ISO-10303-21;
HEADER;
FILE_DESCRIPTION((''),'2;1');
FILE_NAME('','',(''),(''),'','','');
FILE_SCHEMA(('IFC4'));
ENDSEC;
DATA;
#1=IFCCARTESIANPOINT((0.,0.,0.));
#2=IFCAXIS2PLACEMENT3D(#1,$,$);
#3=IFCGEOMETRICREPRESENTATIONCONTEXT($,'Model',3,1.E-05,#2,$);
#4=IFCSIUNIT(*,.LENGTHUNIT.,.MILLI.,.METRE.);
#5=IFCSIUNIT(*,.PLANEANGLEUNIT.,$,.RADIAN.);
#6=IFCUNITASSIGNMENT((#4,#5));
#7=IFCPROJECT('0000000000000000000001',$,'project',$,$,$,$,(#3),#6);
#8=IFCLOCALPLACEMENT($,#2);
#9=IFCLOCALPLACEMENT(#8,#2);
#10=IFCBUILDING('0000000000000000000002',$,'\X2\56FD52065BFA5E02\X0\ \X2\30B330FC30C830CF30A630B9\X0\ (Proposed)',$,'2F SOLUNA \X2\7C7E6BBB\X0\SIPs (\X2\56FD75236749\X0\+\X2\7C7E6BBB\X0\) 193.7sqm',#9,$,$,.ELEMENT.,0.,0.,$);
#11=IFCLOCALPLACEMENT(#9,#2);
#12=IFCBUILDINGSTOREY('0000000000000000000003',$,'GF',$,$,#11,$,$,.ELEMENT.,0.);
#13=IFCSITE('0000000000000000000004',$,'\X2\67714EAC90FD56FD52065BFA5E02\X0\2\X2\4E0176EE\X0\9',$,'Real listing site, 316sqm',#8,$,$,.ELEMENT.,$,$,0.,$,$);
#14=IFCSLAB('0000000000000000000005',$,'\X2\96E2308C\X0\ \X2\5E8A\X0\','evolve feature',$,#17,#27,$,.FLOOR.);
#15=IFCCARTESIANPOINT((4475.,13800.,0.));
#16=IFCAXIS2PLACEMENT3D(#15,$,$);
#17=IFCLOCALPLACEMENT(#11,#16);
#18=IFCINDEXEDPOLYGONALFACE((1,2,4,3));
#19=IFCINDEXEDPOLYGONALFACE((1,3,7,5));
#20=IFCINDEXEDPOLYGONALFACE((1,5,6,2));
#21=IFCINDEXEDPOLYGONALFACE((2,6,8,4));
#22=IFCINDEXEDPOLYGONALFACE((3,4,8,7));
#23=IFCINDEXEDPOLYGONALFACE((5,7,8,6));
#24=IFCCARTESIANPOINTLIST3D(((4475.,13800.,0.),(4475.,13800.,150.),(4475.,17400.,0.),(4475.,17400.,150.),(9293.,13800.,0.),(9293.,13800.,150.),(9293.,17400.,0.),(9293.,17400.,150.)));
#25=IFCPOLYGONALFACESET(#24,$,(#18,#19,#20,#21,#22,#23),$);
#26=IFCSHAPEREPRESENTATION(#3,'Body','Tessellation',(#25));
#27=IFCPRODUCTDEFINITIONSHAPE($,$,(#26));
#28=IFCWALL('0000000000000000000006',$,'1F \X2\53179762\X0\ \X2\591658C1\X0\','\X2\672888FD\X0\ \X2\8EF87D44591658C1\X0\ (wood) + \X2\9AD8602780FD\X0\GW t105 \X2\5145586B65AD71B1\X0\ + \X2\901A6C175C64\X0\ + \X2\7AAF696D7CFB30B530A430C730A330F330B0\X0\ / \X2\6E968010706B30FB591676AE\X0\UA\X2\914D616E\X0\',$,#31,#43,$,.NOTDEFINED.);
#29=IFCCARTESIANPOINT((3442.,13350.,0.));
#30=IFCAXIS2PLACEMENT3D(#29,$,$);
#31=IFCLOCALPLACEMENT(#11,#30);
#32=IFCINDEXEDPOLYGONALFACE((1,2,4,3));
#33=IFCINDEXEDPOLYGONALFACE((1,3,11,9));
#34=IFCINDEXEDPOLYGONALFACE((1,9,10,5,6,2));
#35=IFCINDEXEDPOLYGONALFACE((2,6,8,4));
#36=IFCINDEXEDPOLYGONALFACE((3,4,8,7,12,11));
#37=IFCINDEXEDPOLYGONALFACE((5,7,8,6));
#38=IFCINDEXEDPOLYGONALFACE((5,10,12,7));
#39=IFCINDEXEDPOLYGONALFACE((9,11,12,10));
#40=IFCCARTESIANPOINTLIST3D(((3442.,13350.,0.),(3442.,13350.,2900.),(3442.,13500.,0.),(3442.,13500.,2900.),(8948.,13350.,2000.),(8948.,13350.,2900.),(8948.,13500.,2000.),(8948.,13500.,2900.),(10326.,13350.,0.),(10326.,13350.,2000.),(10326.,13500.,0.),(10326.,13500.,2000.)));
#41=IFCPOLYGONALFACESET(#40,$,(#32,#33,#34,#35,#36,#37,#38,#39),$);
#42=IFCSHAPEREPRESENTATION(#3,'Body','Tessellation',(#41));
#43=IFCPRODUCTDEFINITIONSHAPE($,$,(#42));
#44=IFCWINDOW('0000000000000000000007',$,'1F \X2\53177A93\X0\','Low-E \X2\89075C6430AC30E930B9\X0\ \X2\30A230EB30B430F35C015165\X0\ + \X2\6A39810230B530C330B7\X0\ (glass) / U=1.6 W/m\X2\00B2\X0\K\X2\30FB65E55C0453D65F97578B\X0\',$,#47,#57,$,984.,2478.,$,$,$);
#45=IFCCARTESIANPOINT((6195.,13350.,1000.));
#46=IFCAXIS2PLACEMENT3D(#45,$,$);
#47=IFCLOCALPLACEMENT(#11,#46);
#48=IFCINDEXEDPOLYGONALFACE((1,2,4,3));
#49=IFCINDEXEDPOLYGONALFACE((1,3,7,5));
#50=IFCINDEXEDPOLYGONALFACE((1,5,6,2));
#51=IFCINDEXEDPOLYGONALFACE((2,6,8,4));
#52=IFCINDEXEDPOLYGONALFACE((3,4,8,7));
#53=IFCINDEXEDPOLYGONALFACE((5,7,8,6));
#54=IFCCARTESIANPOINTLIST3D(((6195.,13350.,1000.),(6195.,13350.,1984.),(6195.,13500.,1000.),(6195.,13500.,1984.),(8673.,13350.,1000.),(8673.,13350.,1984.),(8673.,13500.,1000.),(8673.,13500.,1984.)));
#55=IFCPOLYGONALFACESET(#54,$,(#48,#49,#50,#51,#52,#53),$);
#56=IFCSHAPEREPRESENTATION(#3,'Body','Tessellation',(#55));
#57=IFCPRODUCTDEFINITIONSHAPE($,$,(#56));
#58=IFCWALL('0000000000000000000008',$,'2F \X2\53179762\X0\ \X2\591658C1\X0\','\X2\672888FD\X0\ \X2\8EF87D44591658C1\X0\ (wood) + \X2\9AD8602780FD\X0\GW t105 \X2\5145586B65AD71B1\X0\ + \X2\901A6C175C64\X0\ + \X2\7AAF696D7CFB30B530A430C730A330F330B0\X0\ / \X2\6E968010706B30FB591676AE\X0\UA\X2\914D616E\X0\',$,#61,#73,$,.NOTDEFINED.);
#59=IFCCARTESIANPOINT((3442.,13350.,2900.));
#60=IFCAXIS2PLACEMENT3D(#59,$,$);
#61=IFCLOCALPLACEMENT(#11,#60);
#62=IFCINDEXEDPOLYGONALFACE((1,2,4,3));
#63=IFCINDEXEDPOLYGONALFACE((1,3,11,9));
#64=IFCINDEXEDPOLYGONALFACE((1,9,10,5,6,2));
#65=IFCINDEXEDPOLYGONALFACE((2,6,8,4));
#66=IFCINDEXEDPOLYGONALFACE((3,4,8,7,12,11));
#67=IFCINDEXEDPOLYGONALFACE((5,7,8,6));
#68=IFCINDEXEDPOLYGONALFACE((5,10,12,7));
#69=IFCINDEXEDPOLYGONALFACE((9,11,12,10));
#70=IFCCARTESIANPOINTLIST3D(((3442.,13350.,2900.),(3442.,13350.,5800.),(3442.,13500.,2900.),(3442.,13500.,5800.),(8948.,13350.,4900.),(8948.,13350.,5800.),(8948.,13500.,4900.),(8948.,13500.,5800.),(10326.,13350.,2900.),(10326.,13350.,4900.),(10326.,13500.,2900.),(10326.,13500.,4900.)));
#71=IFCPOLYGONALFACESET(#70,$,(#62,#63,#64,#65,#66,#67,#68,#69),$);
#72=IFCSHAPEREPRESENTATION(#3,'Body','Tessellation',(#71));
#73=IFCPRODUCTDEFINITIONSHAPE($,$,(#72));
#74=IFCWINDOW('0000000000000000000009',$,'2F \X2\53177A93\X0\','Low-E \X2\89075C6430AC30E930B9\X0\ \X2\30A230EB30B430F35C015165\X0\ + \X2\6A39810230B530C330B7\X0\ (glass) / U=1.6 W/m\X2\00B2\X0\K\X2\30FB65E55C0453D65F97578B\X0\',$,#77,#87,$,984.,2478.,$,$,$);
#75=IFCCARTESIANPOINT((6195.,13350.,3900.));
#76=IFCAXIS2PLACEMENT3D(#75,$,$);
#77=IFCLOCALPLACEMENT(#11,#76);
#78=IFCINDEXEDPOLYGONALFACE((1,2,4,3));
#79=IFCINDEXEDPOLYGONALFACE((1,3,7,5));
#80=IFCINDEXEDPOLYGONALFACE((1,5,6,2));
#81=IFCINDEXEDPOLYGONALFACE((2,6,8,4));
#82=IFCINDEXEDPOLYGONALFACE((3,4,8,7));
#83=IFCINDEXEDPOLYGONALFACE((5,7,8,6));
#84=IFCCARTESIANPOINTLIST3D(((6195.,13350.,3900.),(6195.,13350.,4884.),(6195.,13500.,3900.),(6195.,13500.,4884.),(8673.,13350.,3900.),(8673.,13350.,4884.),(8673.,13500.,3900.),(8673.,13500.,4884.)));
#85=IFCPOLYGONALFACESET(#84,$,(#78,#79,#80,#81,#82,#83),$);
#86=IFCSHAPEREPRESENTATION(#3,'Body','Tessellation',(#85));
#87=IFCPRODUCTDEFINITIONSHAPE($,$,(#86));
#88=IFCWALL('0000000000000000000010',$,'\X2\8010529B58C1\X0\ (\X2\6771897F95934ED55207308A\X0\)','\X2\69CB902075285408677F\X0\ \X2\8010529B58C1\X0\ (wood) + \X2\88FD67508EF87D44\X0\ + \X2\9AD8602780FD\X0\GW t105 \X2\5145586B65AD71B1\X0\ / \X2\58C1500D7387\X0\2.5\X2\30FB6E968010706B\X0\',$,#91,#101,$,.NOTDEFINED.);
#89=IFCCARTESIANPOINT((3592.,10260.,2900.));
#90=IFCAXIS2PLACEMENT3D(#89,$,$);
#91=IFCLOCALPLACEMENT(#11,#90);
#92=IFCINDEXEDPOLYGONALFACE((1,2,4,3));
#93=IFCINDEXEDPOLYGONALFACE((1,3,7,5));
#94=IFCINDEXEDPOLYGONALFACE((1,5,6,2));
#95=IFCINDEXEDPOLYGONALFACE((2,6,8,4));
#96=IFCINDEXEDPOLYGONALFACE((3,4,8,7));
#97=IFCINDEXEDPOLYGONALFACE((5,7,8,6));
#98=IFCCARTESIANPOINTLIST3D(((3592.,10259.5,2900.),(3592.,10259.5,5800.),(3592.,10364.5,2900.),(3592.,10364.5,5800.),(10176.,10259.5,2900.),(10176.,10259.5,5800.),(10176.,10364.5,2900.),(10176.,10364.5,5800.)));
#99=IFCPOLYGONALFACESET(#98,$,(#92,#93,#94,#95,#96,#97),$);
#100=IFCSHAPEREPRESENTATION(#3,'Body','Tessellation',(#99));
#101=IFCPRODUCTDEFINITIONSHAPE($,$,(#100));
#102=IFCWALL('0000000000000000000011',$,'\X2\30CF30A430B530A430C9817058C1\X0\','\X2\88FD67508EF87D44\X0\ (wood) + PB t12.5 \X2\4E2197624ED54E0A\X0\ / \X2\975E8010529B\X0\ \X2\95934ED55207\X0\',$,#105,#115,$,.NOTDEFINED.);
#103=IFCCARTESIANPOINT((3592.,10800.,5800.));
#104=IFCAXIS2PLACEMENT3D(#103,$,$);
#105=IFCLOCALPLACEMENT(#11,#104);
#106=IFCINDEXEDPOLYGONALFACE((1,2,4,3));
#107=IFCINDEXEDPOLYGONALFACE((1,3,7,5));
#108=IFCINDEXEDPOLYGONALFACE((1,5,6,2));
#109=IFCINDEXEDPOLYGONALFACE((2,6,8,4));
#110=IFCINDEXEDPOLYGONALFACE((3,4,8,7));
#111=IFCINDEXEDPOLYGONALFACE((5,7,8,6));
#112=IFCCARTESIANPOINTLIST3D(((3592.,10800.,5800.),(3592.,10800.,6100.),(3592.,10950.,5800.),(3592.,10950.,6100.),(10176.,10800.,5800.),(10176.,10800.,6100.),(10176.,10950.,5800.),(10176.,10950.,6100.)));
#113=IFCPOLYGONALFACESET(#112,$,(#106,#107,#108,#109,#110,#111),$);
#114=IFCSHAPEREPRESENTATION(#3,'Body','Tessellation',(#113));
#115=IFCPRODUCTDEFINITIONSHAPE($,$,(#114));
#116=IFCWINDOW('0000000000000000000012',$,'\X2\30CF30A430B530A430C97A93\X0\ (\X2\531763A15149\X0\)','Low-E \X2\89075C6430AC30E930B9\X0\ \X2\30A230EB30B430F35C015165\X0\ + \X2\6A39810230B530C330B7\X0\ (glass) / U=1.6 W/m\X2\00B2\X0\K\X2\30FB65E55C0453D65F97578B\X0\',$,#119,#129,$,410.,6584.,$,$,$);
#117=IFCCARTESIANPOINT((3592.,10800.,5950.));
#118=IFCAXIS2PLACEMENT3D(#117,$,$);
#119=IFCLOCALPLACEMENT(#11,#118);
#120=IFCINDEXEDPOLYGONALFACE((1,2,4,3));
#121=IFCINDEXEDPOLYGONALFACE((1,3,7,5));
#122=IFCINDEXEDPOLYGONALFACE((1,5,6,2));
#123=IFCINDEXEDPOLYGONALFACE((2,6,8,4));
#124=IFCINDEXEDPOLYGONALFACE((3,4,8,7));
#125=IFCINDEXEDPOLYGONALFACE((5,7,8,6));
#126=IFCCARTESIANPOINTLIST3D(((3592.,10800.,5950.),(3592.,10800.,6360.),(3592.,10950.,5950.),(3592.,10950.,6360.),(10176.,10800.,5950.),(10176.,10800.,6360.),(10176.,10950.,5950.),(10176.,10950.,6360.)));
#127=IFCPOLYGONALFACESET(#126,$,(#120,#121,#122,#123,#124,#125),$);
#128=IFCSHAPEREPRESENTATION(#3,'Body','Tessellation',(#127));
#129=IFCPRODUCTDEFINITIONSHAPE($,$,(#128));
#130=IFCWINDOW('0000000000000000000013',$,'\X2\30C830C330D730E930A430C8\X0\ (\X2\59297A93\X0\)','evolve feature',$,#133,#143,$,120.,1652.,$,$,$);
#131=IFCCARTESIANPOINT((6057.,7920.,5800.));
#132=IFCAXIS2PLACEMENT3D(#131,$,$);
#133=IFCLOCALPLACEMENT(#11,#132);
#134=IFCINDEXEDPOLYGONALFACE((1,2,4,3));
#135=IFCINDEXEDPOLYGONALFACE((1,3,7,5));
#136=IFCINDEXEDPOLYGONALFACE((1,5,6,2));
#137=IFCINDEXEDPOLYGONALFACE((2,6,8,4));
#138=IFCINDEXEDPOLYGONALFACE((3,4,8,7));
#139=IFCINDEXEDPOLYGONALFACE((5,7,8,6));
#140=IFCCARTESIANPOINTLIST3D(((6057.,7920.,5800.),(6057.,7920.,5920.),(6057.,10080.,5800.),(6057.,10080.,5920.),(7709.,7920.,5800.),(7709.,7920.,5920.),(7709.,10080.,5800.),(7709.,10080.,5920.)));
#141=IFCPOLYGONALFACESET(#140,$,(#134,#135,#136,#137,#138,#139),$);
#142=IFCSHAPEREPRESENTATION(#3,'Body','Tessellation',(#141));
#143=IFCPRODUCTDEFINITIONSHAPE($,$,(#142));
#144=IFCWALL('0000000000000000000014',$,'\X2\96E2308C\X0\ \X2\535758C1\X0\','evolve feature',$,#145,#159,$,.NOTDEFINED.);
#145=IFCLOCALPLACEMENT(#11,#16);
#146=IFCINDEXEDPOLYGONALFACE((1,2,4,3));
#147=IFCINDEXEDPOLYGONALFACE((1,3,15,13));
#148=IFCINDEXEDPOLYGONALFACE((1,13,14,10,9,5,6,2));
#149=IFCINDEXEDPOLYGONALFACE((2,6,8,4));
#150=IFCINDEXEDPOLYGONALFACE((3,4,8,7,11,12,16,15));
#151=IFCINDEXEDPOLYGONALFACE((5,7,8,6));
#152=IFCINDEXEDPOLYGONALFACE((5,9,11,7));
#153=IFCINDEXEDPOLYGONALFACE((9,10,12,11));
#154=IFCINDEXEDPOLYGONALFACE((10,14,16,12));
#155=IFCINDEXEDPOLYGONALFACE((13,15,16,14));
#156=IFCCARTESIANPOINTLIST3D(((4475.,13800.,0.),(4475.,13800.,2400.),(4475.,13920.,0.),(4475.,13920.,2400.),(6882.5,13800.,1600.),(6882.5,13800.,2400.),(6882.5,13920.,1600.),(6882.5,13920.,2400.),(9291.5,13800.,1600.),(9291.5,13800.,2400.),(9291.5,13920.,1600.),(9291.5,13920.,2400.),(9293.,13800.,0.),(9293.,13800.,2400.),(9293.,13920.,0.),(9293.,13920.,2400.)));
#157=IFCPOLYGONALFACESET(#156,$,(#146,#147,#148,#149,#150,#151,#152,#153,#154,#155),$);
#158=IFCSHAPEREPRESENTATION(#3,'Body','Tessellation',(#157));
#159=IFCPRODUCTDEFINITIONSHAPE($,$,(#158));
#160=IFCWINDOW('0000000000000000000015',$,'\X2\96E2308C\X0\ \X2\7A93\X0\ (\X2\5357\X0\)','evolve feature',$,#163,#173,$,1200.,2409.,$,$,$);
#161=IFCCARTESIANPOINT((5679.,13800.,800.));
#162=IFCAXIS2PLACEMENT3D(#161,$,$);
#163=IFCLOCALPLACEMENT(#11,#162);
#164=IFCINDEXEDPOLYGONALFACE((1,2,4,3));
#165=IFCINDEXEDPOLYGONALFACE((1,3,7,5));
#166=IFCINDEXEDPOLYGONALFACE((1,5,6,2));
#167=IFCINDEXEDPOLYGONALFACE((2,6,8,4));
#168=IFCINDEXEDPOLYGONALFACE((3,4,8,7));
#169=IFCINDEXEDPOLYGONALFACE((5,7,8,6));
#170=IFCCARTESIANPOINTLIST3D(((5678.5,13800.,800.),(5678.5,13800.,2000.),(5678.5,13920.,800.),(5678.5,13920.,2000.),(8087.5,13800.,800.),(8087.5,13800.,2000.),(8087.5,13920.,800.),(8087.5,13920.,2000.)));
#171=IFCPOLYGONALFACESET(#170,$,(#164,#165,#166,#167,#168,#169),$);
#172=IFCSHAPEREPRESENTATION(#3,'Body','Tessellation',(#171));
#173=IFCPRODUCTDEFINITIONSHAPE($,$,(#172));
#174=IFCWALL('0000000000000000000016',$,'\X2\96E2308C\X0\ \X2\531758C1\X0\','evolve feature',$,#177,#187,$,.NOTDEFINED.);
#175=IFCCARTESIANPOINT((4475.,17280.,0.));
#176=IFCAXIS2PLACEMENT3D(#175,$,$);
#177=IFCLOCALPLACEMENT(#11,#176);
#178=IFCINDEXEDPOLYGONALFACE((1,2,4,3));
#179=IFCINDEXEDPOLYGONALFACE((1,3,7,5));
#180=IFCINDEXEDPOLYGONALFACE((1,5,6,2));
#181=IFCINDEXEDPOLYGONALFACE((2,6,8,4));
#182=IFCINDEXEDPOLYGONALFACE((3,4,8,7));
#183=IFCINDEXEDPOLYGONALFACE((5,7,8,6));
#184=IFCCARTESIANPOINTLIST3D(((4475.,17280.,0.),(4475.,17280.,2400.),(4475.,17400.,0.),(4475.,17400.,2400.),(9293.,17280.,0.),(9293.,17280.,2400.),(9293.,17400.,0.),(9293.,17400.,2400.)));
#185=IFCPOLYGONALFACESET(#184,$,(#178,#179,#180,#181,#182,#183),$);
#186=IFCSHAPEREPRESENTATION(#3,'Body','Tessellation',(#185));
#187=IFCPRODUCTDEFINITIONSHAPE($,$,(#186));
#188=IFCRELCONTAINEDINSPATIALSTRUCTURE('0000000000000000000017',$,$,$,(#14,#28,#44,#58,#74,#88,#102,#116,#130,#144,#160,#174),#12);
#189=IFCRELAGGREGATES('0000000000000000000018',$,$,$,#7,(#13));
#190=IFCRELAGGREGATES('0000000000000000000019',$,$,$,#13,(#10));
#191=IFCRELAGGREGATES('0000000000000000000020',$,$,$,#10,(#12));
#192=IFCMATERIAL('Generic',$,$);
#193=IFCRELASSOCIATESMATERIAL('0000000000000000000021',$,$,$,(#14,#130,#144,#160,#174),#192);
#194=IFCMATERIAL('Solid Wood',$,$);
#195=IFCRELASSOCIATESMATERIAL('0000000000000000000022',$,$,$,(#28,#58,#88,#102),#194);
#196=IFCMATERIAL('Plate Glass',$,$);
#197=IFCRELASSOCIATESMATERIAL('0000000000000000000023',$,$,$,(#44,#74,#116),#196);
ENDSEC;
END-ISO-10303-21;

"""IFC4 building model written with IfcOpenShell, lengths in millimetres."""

from ifc_helpers import new_model, si_unit, frame, frame_2d, origin, place, context, project, spatial, rectangle, extrude, material, element, fill, save


model = new_model("IFC4")

# Units and contexts
model_context = context("Model", 3, precision=1e-05, world=origin())
ifc_project = project(units=[si_unit("LENGTHUNIT", "METRE", prefix="MILLI"), si_unit("PLANEANGLEUNIT", "RADIAN")], contexts=[model_context])

# Site, building, storey
site_placement = place(None, origin())
site = spatial("IfcSite", under=ifc_project, at=site_placement, Name="東京都国分寺市2丁目9", ObjectType="Real listing site, 316sqm", CompositionType="ELEMENT", RefElevation=0.0)
building_placement = place(site_placement, origin())
building = spatial("IfcBuilding", under=site, at=building_placement, Name="国分寺市 コートハウス (Proposed)", ObjectType="2F SOLUNA 籾殻SIPs (国産杉+籾殻) 193.7sqm", CompositionType="ELEMENT", ElevationOfRefHeight=0.0, ElevationOfTerrain=0.0)
storey_placement = place(building_placement, origin())
storey = spatial("IfcBuildingStorey", under=building, at=storey_placement, Name="GF", CompositionType="ELEMENT", Elevation=0.0)

# Slab
ifc_material_1 = material(Name="Generic")
slab_placement = place(storey_placement, frame((4475.0, 13800.0, 0.0)))
element("IfcSlab", 1, at=slab_placement, inside=storey, material=ifc_material_1, Name="離れ 床", Description="evolve feature", PredefinedType="FLOOR", context=model_context, shape_type="SweptSolid", body=[
    extrude(rectangle(XDim=4818.0, YDim=3600.0, at=frame_2d((2409.0, 1800.0))), frame((4475.0, 13800.0, 0.0)), (0.0, 0.0, 1.0), 150.0),
])

# Wall, opening, window
ifc_material_2 = material(Name="Solid Wood")
wall_1_placement = place(storey_placement, frame((3442.0, 13350.0, 0.0)))
wall_1 = element("IfcWall", 2, at=wall_1_placement, inside=storey, material=ifc_material_2, Name="1F 北面 外壁", Description="木製 軸組外壁 (wood) + 高性能GW t105 充填断熱 + 通気層 + 窯業系サイディング / 準耐火・外皮UA配慮", PredefinedType="NOTDEFINED", context=model_context, shape_type="SweptSolid", body=[
    extrude(rectangle(XDim=6884.0, YDim=150.0, at=frame_2d((3442.0, 75.0))), frame((3442.0, 13350.0, 0.0)), (0.0, 0.0, 1.0), 2900.0),
])
opening_1_placement = place(storey_placement, frame((6195.0, 13350.0, 1000.0)))
opening_1 = element("IfcOpeningElement", 3, at=opening_1_placement, cuts=wall_1, PredefinedType="NOTDEFINED", context=model_context, shape_type="SweptSolid", body=[
    extrude(rectangle(XDim=2478.0, YDim=150.0, at=frame_2d((1239.0, 75.0))), frame((6195.0, 13350.0, 1000.0)), (0.0, 0.0, 1.0), 984.0),
])
ifc_material_3 = material(Name="Plate Glass")
window_1_placement = place(storey_placement, frame((6195.0, 13350.0, 1000.0)))
window_1 = element("IfcWindow", 4, at=window_1_placement, inside=storey, material=ifc_material_3, Name="1F 北窓", Description="Low-E 複層ガラス アルゴン封入 + 樹脂サッシ (glass) / U=1.6 W/m²K・日射取得型", OverallHeight=984.0, OverallWidth=2478.0, context=model_context, shape_type="SweptSolid", body=[
    extrude(rectangle(XDim=2478.0, YDim=150.0, at=frame_2d((1239.0, 75.0))), frame((6195.0, 13350.0, 1000.0)), (0.0, 0.0, 1.0), 984.0),
])
fill(opening_1, window_1)

# Wall, opening, window
wall_2_placement = place(storey_placement, frame((3442.0, 13350.0, 2900.0)))
wall_2 = element("IfcWall", 5, at=wall_2_placement, inside=storey, material=ifc_material_2, Name="2F 北面 外壁", Description="木製 軸組外壁 (wood) + 高性能GW t105 充填断熱 + 通気層 + 窯業系サイディング / 準耐火・外皮UA配慮", PredefinedType="NOTDEFINED", context=model_context, shape_type="SweptSolid", body=[
    extrude(rectangle(XDim=6884.0, YDim=150.0, at=frame_2d((3442.0, 75.0))), frame((3442.0, 13350.0, 2900.0)), (0.0, 0.0, 1.0), 2900.0),
])
opening_2_placement = place(storey_placement, frame((6195.0, 13350.0, 3900.0)))
opening_2 = element("IfcOpeningElement", 6, at=opening_2_placement, cuts=wall_2, PredefinedType="NOTDEFINED", context=model_context, shape_type="SweptSolid", body=[
    extrude(rectangle(XDim=2478.0, YDim=150.0, at=frame_2d((1239.0, 75.0))), frame((6195.0, 13350.0, 3900.0)), (0.0, 0.0, 1.0), 984.0),
])
window_2_placement = place(storey_placement, frame((6195.0, 13350.0, 3900.0)))
window_2 = element("IfcWindow", 7, at=window_2_placement, inside=storey, material=ifc_material_3, Name="2F 北窓", Description="Low-E 複層ガラス アルゴン封入 + 樹脂サッシ (glass) / U=1.6 W/m²K・日射取得型", OverallHeight=984.0, OverallWidth=2478.0, context=model_context, shape_type="SweptSolid", body=[
    extrude(rectangle(XDim=2478.0, YDim=150.0, at=frame_2d((1239.0, 75.0))), frame((6195.0, 13350.0, 3900.0)), (0.0, 0.0, 1.0), 984.0),
])
fill(opening_2, window_2)

# Wall
wall_3_placement = place(storey_placement, frame((3592.0, 10260.0, 2900.0)))
element("IfcWall", 8, at=wall_3_placement, inside=storey, material=ifc_material_2, Name="耐力壁 (東西間仕切り)", Description="構造用合板 耐力壁 (wood) + 製材軸組 + 高性能GW t105 充填断熱 / 壁倍率2.5・準耐火", PredefinedType="NOTDEFINED", context=model_context, shape_type="SweptSolid", body=[
    extrude(rectangle(XDim=6584.0, YDim=105.0, at=frame_2d((3292.0, 52.0))), frame((3592.0, 10260.0, 2900.0)), (0.0, 0.0, 1.0), 2900.0),
])

# Wall, opening, window
wall_4_placement = place(storey_placement, frame((3592.0, 10800.0, 5800.0)))
wall_4 = element("IfcWall", 9, at=wall_4_placement, inside=storey, material=ifc_material_2, Name="ハイサイド腰壁", Description="製材軸組 (wood) + PB t12.5 両面仕上 / 非耐力 間仕切", PredefinedType="NOTDEFINED", context=model_context, shape_type="SweptSolid", body=[
    extrude(rectangle(XDim=6584.0, YDim=150.0, at=frame_2d((3292.0, 75.0))), frame((3592.0, 10800.0, 5800.0)), (0.0, 0.0, 1.0), 700.0),
])
opening_3_placement = place(storey_placement, frame((3592.0, 10800.0, 5950.0)))
opening_3 = element("IfcOpeningElement", 10, at=opening_3_placement, cuts=wall_4, PredefinedType="NOTDEFINED", context=model_context, shape_type="SweptSolid", body=[
    extrude(rectangle(XDim=6584.0, YDim=150.0, at=frame_2d((3292.0, 75.0))), frame((3592.0, 10800.0, 5950.0)), (0.0, 0.0, 1.0), 410.0),
])
window_3_placement = place(storey_placement, frame((3592.0, 10800.0, 5950.0)))
window_3 = element("IfcWindow", 11, at=window_3_placement, inside=storey, material=ifc_material_3, Name="ハイサイド窓 (北採光)", Description="Low-E 複層ガラス アルゴン封入 + 樹脂サッシ (glass) / U=1.6 W/m²K・日射取得型", OverallHeight=410.0, OverallWidth=6584.0, context=model_context, shape_type="SweptSolid", body=[
    extrude(rectangle(XDim=6584.0, YDim=150.0, at=frame_2d((3292.0, 75.0))), frame((3592.0, 10800.0, 5950.0)), (0.0, 0.0, 1.0), 410.0),
])
fill(opening_3, window_3)

# Window
window_4_placement = place(storey_placement, frame((6057.0, 7920.0, 5800.0)))
element("IfcWindow", 12, at=window_4_placement, inside=storey, material=ifc_material_1, Name="トップライト (天窓)", Description="evolve feature", OverallHeight=120.0, OverallWidth=1652.0, context=model_context, shape_type="SweptSolid", body=[
    extrude(rectangle(XDim=1652.0, YDim=2160.0, at=frame_2d((826.0, 1080.0))), frame((6057.0, 7920.0, 5800.0)), (0.0, 0.0, 1.0), 120.0),
])

# Wall, opening, window
wall_5_placement = place(storey_placement, frame((4475.0, 13800.0, 0.0)))
wall_5 = element("IfcWall", 13, at=wall_5_placement, inside=storey, material=ifc_material_1, Name="離れ 南壁", Description="evolve feature", PredefinedType="NOTDEFINED", context=model_context, shape_type="SweptSolid", body=[
    extrude(rectangle(XDim=4818.0, YDim=120.0, at=frame_2d((2409.0, 60.0))), frame((4475.0, 13800.0, 0.0)), (0.0, 0.0, 1.0), 2400.0),
])
opening_4_placement = place(storey_placement, frame((5679.0, 13800.0, 800.0)))
opening_4 = element("IfcOpeningElement", 14, at=opening_4_placement, cuts=wall_5, PredefinedType="NOTDEFINED", context=model_context, shape_type="SweptSolid", body=[
    extrude(rectangle(XDim=2409.0, YDim=120.0, at=frame_2d((1204.0, 60.0))), frame((5679.0, 13800.0, 800.0)), (0.0, 0.0, 1.0), 1200.0),
])
window_5_placement = place(storey_placement, frame((5679.0, 13800.0, 800.0)))
window_5 = element("IfcWindow", 15, at=window_5_placement, inside=storey, material=ifc_material_1, Name="離れ 窓 (南)", Description="evolve feature", OverallHeight=1200.0, OverallWidth=2409.0, context=model_context, shape_type="SweptSolid", body=[
    extrude(rectangle(XDim=2409.0, YDim=120.0, at=frame_2d((1204.0, 60.0))), frame((5679.0, 13800.0, 800.0)), (0.0, 0.0, 1.0), 1200.0),
])
fill(opening_4, window_5)

# Wall
wall_6_placement = place(storey_placement, frame((4475.0, 17280.0, 0.0)))
element("IfcWall", 16, at=wall_6_placement, inside=storey, material=ifc_material_1, Name="離れ 北壁", Description="evolve feature", PredefinedType="NOTDEFINED", context=model_context, shape_type="SweptSolid", body=[
    extrude(rectangle(XDim=4818.0, YDim=120.0, at=frame_2d((2409.0, 60.0))), frame((4475.0, 17280.0, 0.0)), (0.0, 0.0, 1.0), 2400.0),
])

save(model, "model.ifc")
